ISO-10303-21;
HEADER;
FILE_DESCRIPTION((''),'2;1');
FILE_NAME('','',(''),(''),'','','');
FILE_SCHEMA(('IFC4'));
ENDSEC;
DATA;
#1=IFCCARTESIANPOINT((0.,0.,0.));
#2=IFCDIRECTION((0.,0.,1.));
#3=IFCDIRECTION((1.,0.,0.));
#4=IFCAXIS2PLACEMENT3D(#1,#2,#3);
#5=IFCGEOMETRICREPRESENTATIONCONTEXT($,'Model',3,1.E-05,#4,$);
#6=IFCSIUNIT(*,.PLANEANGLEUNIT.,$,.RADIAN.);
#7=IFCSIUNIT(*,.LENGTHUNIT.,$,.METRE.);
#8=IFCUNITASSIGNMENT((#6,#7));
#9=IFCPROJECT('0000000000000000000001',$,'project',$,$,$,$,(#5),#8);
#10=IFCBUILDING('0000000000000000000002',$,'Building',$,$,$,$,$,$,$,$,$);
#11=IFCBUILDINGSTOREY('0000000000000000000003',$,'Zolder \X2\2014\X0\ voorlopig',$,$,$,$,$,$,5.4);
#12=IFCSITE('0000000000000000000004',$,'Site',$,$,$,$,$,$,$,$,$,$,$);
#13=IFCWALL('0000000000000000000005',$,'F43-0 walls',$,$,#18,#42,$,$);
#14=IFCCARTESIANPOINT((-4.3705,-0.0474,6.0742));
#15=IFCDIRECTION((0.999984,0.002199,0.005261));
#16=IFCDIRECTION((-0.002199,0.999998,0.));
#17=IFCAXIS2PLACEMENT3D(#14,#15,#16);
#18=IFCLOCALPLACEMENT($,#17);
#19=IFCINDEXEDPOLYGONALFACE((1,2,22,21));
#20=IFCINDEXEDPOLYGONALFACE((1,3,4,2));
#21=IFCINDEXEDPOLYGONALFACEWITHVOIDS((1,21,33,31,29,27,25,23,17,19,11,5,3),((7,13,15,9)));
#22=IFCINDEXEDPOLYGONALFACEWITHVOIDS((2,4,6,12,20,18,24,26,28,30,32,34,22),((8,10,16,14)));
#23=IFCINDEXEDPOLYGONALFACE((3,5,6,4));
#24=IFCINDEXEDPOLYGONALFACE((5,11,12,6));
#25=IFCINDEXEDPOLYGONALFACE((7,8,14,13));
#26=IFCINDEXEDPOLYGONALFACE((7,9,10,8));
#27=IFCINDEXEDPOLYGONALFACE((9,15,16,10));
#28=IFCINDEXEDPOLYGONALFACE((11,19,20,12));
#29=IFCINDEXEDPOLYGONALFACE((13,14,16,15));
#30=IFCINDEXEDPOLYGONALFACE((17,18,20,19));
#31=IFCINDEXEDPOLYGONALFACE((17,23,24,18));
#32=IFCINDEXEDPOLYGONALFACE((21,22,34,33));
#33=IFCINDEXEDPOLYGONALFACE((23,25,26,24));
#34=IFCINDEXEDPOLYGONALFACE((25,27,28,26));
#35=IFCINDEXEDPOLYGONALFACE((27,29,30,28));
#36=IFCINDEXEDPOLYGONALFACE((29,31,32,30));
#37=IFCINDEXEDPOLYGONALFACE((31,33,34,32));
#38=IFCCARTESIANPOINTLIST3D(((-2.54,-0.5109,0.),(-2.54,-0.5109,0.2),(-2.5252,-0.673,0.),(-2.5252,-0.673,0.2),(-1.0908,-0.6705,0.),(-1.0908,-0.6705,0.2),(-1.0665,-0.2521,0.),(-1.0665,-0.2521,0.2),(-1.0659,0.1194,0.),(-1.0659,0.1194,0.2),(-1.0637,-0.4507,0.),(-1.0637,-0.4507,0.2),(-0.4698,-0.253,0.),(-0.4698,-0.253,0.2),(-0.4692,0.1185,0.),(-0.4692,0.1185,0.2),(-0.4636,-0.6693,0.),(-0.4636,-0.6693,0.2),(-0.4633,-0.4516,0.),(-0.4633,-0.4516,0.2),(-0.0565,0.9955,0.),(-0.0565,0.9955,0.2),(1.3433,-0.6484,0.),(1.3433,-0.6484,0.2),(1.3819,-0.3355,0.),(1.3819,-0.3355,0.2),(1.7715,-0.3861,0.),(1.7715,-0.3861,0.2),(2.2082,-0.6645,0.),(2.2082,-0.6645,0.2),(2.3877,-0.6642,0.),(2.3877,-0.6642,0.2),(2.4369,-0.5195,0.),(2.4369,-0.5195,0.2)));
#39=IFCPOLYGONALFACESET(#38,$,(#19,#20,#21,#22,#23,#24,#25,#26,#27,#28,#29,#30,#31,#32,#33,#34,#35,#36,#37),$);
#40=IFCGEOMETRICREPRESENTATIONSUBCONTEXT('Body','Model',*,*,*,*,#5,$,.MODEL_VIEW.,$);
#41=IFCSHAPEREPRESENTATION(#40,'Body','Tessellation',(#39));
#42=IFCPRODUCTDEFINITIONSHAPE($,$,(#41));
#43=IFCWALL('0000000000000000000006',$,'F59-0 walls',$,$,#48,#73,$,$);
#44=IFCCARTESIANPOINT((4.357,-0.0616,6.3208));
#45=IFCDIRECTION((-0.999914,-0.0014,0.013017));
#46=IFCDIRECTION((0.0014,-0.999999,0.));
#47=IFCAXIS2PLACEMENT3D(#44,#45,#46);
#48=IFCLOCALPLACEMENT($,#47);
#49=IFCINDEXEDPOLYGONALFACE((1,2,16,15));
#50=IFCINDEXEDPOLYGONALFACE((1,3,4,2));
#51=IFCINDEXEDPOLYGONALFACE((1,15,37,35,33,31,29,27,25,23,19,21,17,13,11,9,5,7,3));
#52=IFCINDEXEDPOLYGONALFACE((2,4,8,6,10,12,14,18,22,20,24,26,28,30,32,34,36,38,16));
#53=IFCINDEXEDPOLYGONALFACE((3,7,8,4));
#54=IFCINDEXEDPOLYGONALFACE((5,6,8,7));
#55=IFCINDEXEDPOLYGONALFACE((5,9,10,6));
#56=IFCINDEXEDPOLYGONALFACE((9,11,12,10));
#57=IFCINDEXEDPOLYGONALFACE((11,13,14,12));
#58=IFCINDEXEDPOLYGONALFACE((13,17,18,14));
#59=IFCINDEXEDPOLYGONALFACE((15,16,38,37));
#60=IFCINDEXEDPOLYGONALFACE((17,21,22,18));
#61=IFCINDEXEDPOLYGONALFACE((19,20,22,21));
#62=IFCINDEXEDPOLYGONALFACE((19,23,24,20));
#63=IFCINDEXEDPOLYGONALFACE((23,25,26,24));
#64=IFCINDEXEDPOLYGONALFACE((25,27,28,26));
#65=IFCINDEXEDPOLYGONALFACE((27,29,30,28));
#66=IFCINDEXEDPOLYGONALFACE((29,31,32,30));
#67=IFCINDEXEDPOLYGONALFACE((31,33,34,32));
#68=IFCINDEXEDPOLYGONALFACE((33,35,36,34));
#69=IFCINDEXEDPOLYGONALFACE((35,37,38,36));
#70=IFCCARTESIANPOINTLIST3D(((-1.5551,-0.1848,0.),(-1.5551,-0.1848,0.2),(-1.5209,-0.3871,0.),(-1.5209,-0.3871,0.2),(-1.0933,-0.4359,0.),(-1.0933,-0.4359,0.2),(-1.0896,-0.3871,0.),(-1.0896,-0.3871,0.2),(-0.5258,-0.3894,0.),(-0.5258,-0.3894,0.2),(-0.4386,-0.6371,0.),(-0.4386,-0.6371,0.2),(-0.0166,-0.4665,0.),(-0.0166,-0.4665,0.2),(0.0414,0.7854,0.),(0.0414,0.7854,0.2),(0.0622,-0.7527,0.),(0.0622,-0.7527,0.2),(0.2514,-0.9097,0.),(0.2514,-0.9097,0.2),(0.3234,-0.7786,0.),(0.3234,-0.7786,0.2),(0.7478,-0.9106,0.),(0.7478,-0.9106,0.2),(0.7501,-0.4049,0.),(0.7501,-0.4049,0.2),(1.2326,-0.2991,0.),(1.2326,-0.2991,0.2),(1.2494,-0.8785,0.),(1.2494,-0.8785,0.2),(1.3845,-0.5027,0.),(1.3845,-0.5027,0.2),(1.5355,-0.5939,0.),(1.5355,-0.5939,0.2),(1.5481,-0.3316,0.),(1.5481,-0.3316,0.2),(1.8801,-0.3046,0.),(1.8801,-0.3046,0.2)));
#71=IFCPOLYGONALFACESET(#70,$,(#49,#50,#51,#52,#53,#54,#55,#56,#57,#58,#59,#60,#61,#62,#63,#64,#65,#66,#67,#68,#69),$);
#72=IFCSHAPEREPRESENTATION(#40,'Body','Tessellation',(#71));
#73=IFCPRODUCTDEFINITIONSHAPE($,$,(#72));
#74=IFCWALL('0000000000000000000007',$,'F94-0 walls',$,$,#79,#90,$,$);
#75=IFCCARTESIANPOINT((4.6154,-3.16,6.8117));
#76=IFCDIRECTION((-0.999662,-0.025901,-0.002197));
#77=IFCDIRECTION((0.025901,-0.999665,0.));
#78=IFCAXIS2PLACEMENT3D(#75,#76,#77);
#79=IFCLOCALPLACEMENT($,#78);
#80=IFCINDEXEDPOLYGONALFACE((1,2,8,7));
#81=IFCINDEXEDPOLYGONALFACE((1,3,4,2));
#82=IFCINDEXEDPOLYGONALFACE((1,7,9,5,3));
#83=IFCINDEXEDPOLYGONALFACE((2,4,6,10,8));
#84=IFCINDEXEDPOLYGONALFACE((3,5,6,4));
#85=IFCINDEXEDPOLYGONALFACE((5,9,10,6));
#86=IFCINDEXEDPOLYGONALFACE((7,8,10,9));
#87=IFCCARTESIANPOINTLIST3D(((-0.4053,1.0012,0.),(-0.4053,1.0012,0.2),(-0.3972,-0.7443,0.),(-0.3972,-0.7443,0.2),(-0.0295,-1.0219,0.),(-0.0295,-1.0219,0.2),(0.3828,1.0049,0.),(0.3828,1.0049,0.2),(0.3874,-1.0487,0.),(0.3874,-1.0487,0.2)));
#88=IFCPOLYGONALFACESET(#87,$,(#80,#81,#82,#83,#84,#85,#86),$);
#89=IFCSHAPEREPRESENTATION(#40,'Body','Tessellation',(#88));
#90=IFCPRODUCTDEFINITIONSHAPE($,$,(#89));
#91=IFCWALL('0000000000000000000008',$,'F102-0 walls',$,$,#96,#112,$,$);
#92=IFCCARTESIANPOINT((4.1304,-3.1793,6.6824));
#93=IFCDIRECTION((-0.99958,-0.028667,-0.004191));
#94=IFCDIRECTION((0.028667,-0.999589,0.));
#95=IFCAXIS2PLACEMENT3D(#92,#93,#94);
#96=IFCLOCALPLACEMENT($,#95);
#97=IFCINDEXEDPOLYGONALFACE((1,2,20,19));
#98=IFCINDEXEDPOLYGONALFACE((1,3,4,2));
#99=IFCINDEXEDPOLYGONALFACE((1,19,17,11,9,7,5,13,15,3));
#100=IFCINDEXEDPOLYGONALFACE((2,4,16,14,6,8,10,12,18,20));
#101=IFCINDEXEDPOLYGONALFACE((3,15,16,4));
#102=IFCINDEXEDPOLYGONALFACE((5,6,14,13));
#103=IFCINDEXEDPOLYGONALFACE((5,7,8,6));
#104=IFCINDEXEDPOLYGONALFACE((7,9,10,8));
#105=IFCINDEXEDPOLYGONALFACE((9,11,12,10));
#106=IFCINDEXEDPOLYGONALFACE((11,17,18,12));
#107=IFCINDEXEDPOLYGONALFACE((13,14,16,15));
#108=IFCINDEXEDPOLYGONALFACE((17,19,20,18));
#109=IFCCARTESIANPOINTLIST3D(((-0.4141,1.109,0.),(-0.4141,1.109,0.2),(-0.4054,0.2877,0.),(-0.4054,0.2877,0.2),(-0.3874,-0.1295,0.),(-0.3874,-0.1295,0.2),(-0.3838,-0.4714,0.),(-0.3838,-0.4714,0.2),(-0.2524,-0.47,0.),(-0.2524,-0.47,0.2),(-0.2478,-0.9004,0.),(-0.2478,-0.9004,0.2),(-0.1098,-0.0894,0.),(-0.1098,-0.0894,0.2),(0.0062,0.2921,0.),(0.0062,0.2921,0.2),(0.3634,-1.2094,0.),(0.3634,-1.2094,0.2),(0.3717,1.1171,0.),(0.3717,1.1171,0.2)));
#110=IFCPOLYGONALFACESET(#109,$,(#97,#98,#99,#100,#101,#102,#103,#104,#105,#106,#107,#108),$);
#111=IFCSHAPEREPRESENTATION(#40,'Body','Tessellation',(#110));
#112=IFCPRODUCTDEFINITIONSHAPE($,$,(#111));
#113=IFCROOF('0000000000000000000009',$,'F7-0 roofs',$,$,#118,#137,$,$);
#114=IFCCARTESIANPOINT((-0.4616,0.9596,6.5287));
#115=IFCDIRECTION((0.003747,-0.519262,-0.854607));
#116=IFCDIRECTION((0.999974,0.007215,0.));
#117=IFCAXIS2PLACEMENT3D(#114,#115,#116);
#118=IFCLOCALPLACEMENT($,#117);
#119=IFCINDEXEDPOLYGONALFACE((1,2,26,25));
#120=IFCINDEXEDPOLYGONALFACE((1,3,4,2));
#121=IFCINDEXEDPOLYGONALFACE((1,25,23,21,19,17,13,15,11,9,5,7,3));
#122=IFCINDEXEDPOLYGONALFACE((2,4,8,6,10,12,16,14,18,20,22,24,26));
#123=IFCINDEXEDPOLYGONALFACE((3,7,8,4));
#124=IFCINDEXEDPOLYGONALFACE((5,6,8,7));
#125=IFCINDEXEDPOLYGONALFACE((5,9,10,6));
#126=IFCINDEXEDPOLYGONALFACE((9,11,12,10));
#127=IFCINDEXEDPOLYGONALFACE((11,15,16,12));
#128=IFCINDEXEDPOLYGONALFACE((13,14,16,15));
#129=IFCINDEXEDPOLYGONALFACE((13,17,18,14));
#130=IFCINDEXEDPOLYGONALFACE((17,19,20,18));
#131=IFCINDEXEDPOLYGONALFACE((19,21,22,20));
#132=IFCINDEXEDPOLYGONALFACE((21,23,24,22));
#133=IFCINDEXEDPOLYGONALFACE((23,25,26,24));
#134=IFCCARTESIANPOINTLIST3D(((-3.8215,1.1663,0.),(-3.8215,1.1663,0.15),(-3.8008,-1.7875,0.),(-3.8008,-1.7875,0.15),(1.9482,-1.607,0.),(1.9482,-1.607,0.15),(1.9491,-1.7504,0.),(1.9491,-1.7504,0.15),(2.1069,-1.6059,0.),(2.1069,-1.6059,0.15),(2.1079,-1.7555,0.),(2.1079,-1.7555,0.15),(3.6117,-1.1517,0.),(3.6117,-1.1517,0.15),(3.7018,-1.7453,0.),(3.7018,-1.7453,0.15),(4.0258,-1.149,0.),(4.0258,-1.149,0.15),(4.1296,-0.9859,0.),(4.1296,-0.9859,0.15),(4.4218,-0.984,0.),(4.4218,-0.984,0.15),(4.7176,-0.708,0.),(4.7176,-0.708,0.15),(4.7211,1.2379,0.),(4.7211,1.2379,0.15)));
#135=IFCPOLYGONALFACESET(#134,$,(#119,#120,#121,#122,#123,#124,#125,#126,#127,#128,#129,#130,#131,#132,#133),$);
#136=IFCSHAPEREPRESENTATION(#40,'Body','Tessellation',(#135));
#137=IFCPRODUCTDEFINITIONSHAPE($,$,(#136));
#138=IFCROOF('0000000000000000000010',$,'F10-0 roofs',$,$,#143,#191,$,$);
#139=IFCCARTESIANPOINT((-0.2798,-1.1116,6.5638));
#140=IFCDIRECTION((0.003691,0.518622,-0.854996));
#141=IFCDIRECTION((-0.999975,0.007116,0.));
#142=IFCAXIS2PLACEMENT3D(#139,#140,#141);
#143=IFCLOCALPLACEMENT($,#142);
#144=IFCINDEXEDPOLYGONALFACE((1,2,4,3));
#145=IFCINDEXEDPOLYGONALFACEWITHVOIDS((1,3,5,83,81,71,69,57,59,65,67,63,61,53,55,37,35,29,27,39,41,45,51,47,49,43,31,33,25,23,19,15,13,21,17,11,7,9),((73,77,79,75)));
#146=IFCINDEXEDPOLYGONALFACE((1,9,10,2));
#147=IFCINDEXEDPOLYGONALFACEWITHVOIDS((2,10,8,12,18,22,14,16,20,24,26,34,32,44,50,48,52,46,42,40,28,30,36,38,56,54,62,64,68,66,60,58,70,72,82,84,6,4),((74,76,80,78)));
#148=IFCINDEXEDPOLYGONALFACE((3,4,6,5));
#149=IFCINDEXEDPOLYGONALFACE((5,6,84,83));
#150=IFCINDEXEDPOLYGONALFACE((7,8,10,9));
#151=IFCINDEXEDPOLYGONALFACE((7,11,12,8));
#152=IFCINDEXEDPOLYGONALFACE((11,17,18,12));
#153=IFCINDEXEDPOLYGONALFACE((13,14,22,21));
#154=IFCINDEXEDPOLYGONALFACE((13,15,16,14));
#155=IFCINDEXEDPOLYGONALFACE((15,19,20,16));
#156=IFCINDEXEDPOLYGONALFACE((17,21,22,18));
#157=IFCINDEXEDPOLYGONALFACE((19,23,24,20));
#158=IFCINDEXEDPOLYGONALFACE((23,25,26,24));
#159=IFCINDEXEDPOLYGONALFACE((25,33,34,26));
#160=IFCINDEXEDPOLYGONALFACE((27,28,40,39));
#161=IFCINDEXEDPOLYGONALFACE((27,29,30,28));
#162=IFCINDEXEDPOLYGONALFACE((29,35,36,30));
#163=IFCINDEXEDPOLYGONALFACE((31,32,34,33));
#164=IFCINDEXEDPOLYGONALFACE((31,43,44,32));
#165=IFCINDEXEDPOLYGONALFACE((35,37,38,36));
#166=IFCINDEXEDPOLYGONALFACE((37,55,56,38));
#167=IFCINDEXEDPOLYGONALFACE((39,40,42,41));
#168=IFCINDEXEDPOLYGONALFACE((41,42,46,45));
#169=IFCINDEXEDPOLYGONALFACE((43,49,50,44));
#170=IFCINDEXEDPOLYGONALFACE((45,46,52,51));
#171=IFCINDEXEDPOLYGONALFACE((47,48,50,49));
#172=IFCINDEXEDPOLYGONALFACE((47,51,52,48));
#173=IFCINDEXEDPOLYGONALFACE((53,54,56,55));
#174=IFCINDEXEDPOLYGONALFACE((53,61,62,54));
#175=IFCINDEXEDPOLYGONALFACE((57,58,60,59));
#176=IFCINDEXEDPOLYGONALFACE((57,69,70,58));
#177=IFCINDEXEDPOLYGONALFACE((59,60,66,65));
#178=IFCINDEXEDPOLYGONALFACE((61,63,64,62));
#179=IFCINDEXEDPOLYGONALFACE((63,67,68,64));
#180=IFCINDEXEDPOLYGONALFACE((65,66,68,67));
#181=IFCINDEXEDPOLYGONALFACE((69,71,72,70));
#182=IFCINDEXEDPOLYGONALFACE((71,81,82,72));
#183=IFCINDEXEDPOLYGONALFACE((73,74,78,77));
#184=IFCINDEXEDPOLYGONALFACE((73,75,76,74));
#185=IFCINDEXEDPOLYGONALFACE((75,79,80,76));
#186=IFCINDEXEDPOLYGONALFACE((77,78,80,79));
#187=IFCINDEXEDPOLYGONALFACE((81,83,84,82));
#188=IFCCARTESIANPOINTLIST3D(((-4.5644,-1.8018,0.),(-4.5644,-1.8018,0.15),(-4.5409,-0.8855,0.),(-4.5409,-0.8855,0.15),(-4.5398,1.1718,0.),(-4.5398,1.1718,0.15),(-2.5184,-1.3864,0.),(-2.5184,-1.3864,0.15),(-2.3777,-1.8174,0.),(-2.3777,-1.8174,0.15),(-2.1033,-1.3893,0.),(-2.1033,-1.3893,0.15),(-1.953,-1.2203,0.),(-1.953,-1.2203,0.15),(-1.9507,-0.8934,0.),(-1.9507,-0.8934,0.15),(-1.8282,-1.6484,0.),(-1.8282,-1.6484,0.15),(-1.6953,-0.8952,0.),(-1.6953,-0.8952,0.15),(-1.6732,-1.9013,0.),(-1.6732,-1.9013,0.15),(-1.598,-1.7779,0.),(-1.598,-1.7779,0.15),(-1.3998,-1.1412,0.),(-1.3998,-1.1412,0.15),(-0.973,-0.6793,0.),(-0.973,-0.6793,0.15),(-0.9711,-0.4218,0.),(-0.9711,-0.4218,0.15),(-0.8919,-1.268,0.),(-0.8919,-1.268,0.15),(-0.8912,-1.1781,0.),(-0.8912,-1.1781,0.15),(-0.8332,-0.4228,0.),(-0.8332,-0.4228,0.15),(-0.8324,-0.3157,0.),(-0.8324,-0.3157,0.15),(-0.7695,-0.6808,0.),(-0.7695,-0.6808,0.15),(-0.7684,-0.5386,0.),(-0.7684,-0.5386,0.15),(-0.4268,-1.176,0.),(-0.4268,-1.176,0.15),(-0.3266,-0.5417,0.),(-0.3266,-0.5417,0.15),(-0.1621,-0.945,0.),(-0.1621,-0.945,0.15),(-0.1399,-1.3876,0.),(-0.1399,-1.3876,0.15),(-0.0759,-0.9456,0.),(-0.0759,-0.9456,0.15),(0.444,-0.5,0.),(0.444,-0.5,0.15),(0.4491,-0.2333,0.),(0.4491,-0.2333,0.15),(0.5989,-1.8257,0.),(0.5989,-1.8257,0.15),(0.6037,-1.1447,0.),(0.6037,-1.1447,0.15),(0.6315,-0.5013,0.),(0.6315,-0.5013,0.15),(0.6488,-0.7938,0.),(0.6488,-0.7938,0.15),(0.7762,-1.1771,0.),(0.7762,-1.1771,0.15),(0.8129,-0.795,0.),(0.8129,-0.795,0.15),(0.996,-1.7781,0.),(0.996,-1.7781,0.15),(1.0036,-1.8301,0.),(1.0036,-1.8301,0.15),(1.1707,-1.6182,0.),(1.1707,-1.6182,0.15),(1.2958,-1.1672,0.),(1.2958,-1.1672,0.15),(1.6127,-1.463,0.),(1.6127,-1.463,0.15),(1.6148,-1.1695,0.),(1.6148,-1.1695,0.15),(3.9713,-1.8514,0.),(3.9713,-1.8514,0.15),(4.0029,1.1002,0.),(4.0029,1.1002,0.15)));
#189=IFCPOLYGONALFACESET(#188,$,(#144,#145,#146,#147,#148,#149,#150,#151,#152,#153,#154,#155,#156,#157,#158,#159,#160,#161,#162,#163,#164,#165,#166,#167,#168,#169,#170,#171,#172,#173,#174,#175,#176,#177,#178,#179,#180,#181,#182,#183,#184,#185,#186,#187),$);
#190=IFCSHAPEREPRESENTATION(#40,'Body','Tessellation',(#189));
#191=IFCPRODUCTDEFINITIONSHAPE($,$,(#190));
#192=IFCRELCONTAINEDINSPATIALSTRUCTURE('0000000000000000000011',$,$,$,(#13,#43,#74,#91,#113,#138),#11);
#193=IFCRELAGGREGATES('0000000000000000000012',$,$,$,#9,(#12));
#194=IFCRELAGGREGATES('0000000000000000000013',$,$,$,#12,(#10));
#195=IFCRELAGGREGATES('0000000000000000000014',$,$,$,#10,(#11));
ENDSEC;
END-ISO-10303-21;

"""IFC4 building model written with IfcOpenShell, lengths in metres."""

from ifc_helpers import new_model, si_unit, frame, origin_with_axes, place, context, subcontext, project, spatial, polyline, outline, extrude, element, save


model = new_model("IFC4")

# Units and contexts
model_context = context("Model", 3, precision=1e-05, world=origin_with_axes())
body_context = subcontext(model_context, "Body", "Model", "MODEL_VIEW")
ifc_project = project(units=[si_unit("PLANEANGLEUNIT", "RADIAN"), si_unit("LENGTHUNIT", "METRE")], contexts=[model_context])

# Site, building, storey
site = spatial("IfcSite", under=ifc_project, Name="Site")
building = spatial("IfcBuilding", under=site, Name="Building")
storey = spatial("IfcBuildingStorey", under=building, Name="Zolder — voorlopig", Elevation=5.4)

# Wall, opening
wall_1_placement = place(None, frame((-4.3705, -0.0474, 6.0742), z_axis=(0.999984, 0.002199, 0.005261), x_axis=(-0.002199, 0.999998, 0.0)))
wall_1 = element("IfcWall", 1, at=wall_1_placement, inside=storey, Name="F43-0 walls", context=body_context, shape_type="SweptSolid", body=[
    extrude(outline(polyline([(-2.5252, -0.673), (-1.0908, -0.6705), (-1.0637, -0.4507), (-0.4633, -0.4516), (-0.4636, -0.6693), (1.3433, -0.6484), (1.3819, -0.3355), (1.7715, -0.3861), (2.2082, -0.6645), (2.3877, -0.6642), (2.4369, -0.5195), (-0.0565, 0.9955), (-2.54, -0.5109), (-2.5252, -0.673)])), origin_with_axes(), (0.0, 0.0, 1.0), 0.2),
])
opening_1_placement = place(wall_1_placement, frame((0.0, 0.0, -0.05), z_axis=(0.0, 0.0, 1.0), x_axis=(1.0, 0.0, 0.0)))
element("IfcOpeningElement", 2, at=opening_1_placement, cuts=wall_1, PredefinedType="OPENING", context=body_context, shape_type="SweptSolid", body=[
    extrude(outline(polyline([(-1.0665, -0.2521), (-1.0659, 0.1194), (-0.4692, 0.1185), (-0.4698, -0.253), (-1.0665, -0.2521)])), origin_with_axes(), (0.0, 0.0, 1.0), 0.3),
])

# Walls
wall_2_placement = place(None, frame((4.357, -0.0616, 6.3208), z_axis=(-0.999914, -0.0014, 0.013017), x_axis=(0.0014, -0.999999, 0.0)))
element("IfcWall", 3, at=wall_2_placement, inside=storey, Name="F59-0 walls", context=body_context, shape_type="SweptSolid", body=[
    extrude(outline(polyline([(0.2514, -0.9097), (0.7478, -0.9106), (0.7501, -0.4049), (1.2326, -0.2991), (1.2494, -0.8785), (1.3845, -0.5027), (1.5355, -0.5939), (1.5481, -0.3316), (1.8801, -0.3046), (0.0414, 0.7854), (-1.5551, -0.1848), (-1.5209, -0.3871), (-1.0896, -0.3871), (-1.0933, -0.4359), (-0.5258, -0.3894), (-0.4386, -0.6371), (-0.0166, -0.4665), (0.0622, -0.7527), (0.3234, -0.7786), (0.2514, -0.9097)])), origin_with_axes(), (0.0, 0.0, 1.0), 0.2),
])
wall_3_placement = place(None, frame((4.6154, -3.16, 6.8117), z_axis=(-0.999662, -0.025901, -0.002197), x_axis=(0.025901, -0.999665, 0.0)))
element("IfcWall", 4, at=wall_3_placement, inside=storey, Name="F94-0 walls", context=body_context, shape_type="SweptSolid", body=[
    extrude(outline(polyline([(-0.0295, -1.0219), (0.3874, -1.0487), (0.3828, 1.0049), (-0.4053, 1.0012), (-0.3972, -0.7443), (-0.0295, -1.0219)])), origin_with_axes(), (0.0, 0.0, 1.0), 0.2),
])
wall_4_placement = place(None, frame((4.1304, -3.1793, 6.6824), z_axis=(-0.99958, -0.028667, -0.004191), x_axis=(0.028667, -0.999589, 0.0)))
element("IfcWall", 5, at=wall_4_placement, inside=storey, Name="F102-0 walls", context=body_context, shape_type="SweptSolid", body=[
    extrude(outline(polyline([(0.3634, -1.2094), (0.3717, 1.1171), (-0.4141, 1.109), (-0.4054, 0.2877), (0.0062, 0.2921), (-0.1098, -0.0894), (-0.3874, -0.1295), (-0.3838, -0.4714), (-0.2524, -0.47), (-0.2478, -0.9004), (0.3634, -1.2094)])), origin_with_axes(), (0.0, 0.0, 1.0), 0.2),
])

# Roof
roof_1_placement = place(None, frame((-0.4616, 0.9596, 6.5287), z_axis=(0.003747, -0.519262, -0.854607), x_axis=(0.999974, 0.007215, 0.0)))
element("IfcRoof", 6, at=roof_1_placement, inside=storey, Name="F7-0 roofs", context=body_context, shape_type="SweptSolid", body=[
    extrude(outline(polyline([(-3.8008, -1.7875), (1.9491, -1.7504), (1.9482, -1.607), (2.1069, -1.6059), (2.1079, -1.7555), (3.7018, -1.7453), (3.6117, -1.1517), (4.0258, -1.149), (4.1296, -0.9859), (4.4218, -0.984), (4.7176, -0.708), (4.7211, 1.2379), (-3.8215, 1.1663), (-3.8008, -1.7875)])), origin_with_axes(), (0.0, 0.0, 1.0), 0.15),
])

# Roof, opening
roof_2_placement = place(None, frame((-0.2798, -1.1116, 6.5638), z_axis=(0.003691, 0.518622, -0.854996), x_axis=(-0.999975, 0.007116, 0.0)))
roof_2 = element("IfcRoof", 7, at=roof_2_placement, inside=storey, Name="F10-0 roofs", context=body_context, shape_type="SweptSolid", body=[
    extrude(outline(polyline([(-2.3777, -1.8174), (-2.5184, -1.3864), (-2.1033, -1.3893), (-1.8282, -1.6484), (-1.6732, -1.9013), (-1.953, -1.2203), (-1.9507, -0.8934), (-1.6953, -0.8952), (-1.598, -1.7779), (-1.3998, -1.1412), (-0.8912, -1.1781), (-0.8919, -1.268), (-0.4268, -1.176), (-0.1399, -1.3876), (-0.1621, -0.945), (-0.0759, -0.9456), (-0.3266, -0.5417), (-0.7684, -0.5386), (-0.7695, -0.6808), (-0.973, -0.6793), (-0.9711, -0.4218), (-0.8332, -0.4228), (-0.8324, -0.3157), (0.4491, -0.2333), (0.444, -0.5), (0.6315, -0.5013), (0.6488, -0.7938), (0.8129, -0.795), (0.7762, -1.1771), (0.6037, -1.1447), (0.5989, -1.8257), (0.996, -1.7781), (1.0036, -1.8301), (3.9713, -1.8514), (4.0029, 1.1002), (-4.5398, 1.1718), (-4.5409, -0.8855), (-4.5644, -1.8018), (-2.3777, -1.8174)])), origin_with_axes(), (0.0, 0.0, 1.0), 0.15),
])
opening_2_placement = place(roof_2_placement, frame((0.0, 0.0, -0.05), z_axis=(0.0, 0.0, 1.0), x_axis=(1.0, 0.0, 0.0)))
element("IfcOpeningElement", 8, at=opening_2_placement, cuts=roof_2, PredefinedType="OPENING", context=body_context, shape_type="SweptSolid", body=[
    extrude(outline(polyline([(1.1707, -1.6182), (1.2958, -1.1672), (1.6148, -1.1695), (1.6127, -1.463), (1.1707, -1.6182)])), origin_with_axes(), (0.0, 0.0, 1.0), 0.25),
])

save(model, "model.ifc")
